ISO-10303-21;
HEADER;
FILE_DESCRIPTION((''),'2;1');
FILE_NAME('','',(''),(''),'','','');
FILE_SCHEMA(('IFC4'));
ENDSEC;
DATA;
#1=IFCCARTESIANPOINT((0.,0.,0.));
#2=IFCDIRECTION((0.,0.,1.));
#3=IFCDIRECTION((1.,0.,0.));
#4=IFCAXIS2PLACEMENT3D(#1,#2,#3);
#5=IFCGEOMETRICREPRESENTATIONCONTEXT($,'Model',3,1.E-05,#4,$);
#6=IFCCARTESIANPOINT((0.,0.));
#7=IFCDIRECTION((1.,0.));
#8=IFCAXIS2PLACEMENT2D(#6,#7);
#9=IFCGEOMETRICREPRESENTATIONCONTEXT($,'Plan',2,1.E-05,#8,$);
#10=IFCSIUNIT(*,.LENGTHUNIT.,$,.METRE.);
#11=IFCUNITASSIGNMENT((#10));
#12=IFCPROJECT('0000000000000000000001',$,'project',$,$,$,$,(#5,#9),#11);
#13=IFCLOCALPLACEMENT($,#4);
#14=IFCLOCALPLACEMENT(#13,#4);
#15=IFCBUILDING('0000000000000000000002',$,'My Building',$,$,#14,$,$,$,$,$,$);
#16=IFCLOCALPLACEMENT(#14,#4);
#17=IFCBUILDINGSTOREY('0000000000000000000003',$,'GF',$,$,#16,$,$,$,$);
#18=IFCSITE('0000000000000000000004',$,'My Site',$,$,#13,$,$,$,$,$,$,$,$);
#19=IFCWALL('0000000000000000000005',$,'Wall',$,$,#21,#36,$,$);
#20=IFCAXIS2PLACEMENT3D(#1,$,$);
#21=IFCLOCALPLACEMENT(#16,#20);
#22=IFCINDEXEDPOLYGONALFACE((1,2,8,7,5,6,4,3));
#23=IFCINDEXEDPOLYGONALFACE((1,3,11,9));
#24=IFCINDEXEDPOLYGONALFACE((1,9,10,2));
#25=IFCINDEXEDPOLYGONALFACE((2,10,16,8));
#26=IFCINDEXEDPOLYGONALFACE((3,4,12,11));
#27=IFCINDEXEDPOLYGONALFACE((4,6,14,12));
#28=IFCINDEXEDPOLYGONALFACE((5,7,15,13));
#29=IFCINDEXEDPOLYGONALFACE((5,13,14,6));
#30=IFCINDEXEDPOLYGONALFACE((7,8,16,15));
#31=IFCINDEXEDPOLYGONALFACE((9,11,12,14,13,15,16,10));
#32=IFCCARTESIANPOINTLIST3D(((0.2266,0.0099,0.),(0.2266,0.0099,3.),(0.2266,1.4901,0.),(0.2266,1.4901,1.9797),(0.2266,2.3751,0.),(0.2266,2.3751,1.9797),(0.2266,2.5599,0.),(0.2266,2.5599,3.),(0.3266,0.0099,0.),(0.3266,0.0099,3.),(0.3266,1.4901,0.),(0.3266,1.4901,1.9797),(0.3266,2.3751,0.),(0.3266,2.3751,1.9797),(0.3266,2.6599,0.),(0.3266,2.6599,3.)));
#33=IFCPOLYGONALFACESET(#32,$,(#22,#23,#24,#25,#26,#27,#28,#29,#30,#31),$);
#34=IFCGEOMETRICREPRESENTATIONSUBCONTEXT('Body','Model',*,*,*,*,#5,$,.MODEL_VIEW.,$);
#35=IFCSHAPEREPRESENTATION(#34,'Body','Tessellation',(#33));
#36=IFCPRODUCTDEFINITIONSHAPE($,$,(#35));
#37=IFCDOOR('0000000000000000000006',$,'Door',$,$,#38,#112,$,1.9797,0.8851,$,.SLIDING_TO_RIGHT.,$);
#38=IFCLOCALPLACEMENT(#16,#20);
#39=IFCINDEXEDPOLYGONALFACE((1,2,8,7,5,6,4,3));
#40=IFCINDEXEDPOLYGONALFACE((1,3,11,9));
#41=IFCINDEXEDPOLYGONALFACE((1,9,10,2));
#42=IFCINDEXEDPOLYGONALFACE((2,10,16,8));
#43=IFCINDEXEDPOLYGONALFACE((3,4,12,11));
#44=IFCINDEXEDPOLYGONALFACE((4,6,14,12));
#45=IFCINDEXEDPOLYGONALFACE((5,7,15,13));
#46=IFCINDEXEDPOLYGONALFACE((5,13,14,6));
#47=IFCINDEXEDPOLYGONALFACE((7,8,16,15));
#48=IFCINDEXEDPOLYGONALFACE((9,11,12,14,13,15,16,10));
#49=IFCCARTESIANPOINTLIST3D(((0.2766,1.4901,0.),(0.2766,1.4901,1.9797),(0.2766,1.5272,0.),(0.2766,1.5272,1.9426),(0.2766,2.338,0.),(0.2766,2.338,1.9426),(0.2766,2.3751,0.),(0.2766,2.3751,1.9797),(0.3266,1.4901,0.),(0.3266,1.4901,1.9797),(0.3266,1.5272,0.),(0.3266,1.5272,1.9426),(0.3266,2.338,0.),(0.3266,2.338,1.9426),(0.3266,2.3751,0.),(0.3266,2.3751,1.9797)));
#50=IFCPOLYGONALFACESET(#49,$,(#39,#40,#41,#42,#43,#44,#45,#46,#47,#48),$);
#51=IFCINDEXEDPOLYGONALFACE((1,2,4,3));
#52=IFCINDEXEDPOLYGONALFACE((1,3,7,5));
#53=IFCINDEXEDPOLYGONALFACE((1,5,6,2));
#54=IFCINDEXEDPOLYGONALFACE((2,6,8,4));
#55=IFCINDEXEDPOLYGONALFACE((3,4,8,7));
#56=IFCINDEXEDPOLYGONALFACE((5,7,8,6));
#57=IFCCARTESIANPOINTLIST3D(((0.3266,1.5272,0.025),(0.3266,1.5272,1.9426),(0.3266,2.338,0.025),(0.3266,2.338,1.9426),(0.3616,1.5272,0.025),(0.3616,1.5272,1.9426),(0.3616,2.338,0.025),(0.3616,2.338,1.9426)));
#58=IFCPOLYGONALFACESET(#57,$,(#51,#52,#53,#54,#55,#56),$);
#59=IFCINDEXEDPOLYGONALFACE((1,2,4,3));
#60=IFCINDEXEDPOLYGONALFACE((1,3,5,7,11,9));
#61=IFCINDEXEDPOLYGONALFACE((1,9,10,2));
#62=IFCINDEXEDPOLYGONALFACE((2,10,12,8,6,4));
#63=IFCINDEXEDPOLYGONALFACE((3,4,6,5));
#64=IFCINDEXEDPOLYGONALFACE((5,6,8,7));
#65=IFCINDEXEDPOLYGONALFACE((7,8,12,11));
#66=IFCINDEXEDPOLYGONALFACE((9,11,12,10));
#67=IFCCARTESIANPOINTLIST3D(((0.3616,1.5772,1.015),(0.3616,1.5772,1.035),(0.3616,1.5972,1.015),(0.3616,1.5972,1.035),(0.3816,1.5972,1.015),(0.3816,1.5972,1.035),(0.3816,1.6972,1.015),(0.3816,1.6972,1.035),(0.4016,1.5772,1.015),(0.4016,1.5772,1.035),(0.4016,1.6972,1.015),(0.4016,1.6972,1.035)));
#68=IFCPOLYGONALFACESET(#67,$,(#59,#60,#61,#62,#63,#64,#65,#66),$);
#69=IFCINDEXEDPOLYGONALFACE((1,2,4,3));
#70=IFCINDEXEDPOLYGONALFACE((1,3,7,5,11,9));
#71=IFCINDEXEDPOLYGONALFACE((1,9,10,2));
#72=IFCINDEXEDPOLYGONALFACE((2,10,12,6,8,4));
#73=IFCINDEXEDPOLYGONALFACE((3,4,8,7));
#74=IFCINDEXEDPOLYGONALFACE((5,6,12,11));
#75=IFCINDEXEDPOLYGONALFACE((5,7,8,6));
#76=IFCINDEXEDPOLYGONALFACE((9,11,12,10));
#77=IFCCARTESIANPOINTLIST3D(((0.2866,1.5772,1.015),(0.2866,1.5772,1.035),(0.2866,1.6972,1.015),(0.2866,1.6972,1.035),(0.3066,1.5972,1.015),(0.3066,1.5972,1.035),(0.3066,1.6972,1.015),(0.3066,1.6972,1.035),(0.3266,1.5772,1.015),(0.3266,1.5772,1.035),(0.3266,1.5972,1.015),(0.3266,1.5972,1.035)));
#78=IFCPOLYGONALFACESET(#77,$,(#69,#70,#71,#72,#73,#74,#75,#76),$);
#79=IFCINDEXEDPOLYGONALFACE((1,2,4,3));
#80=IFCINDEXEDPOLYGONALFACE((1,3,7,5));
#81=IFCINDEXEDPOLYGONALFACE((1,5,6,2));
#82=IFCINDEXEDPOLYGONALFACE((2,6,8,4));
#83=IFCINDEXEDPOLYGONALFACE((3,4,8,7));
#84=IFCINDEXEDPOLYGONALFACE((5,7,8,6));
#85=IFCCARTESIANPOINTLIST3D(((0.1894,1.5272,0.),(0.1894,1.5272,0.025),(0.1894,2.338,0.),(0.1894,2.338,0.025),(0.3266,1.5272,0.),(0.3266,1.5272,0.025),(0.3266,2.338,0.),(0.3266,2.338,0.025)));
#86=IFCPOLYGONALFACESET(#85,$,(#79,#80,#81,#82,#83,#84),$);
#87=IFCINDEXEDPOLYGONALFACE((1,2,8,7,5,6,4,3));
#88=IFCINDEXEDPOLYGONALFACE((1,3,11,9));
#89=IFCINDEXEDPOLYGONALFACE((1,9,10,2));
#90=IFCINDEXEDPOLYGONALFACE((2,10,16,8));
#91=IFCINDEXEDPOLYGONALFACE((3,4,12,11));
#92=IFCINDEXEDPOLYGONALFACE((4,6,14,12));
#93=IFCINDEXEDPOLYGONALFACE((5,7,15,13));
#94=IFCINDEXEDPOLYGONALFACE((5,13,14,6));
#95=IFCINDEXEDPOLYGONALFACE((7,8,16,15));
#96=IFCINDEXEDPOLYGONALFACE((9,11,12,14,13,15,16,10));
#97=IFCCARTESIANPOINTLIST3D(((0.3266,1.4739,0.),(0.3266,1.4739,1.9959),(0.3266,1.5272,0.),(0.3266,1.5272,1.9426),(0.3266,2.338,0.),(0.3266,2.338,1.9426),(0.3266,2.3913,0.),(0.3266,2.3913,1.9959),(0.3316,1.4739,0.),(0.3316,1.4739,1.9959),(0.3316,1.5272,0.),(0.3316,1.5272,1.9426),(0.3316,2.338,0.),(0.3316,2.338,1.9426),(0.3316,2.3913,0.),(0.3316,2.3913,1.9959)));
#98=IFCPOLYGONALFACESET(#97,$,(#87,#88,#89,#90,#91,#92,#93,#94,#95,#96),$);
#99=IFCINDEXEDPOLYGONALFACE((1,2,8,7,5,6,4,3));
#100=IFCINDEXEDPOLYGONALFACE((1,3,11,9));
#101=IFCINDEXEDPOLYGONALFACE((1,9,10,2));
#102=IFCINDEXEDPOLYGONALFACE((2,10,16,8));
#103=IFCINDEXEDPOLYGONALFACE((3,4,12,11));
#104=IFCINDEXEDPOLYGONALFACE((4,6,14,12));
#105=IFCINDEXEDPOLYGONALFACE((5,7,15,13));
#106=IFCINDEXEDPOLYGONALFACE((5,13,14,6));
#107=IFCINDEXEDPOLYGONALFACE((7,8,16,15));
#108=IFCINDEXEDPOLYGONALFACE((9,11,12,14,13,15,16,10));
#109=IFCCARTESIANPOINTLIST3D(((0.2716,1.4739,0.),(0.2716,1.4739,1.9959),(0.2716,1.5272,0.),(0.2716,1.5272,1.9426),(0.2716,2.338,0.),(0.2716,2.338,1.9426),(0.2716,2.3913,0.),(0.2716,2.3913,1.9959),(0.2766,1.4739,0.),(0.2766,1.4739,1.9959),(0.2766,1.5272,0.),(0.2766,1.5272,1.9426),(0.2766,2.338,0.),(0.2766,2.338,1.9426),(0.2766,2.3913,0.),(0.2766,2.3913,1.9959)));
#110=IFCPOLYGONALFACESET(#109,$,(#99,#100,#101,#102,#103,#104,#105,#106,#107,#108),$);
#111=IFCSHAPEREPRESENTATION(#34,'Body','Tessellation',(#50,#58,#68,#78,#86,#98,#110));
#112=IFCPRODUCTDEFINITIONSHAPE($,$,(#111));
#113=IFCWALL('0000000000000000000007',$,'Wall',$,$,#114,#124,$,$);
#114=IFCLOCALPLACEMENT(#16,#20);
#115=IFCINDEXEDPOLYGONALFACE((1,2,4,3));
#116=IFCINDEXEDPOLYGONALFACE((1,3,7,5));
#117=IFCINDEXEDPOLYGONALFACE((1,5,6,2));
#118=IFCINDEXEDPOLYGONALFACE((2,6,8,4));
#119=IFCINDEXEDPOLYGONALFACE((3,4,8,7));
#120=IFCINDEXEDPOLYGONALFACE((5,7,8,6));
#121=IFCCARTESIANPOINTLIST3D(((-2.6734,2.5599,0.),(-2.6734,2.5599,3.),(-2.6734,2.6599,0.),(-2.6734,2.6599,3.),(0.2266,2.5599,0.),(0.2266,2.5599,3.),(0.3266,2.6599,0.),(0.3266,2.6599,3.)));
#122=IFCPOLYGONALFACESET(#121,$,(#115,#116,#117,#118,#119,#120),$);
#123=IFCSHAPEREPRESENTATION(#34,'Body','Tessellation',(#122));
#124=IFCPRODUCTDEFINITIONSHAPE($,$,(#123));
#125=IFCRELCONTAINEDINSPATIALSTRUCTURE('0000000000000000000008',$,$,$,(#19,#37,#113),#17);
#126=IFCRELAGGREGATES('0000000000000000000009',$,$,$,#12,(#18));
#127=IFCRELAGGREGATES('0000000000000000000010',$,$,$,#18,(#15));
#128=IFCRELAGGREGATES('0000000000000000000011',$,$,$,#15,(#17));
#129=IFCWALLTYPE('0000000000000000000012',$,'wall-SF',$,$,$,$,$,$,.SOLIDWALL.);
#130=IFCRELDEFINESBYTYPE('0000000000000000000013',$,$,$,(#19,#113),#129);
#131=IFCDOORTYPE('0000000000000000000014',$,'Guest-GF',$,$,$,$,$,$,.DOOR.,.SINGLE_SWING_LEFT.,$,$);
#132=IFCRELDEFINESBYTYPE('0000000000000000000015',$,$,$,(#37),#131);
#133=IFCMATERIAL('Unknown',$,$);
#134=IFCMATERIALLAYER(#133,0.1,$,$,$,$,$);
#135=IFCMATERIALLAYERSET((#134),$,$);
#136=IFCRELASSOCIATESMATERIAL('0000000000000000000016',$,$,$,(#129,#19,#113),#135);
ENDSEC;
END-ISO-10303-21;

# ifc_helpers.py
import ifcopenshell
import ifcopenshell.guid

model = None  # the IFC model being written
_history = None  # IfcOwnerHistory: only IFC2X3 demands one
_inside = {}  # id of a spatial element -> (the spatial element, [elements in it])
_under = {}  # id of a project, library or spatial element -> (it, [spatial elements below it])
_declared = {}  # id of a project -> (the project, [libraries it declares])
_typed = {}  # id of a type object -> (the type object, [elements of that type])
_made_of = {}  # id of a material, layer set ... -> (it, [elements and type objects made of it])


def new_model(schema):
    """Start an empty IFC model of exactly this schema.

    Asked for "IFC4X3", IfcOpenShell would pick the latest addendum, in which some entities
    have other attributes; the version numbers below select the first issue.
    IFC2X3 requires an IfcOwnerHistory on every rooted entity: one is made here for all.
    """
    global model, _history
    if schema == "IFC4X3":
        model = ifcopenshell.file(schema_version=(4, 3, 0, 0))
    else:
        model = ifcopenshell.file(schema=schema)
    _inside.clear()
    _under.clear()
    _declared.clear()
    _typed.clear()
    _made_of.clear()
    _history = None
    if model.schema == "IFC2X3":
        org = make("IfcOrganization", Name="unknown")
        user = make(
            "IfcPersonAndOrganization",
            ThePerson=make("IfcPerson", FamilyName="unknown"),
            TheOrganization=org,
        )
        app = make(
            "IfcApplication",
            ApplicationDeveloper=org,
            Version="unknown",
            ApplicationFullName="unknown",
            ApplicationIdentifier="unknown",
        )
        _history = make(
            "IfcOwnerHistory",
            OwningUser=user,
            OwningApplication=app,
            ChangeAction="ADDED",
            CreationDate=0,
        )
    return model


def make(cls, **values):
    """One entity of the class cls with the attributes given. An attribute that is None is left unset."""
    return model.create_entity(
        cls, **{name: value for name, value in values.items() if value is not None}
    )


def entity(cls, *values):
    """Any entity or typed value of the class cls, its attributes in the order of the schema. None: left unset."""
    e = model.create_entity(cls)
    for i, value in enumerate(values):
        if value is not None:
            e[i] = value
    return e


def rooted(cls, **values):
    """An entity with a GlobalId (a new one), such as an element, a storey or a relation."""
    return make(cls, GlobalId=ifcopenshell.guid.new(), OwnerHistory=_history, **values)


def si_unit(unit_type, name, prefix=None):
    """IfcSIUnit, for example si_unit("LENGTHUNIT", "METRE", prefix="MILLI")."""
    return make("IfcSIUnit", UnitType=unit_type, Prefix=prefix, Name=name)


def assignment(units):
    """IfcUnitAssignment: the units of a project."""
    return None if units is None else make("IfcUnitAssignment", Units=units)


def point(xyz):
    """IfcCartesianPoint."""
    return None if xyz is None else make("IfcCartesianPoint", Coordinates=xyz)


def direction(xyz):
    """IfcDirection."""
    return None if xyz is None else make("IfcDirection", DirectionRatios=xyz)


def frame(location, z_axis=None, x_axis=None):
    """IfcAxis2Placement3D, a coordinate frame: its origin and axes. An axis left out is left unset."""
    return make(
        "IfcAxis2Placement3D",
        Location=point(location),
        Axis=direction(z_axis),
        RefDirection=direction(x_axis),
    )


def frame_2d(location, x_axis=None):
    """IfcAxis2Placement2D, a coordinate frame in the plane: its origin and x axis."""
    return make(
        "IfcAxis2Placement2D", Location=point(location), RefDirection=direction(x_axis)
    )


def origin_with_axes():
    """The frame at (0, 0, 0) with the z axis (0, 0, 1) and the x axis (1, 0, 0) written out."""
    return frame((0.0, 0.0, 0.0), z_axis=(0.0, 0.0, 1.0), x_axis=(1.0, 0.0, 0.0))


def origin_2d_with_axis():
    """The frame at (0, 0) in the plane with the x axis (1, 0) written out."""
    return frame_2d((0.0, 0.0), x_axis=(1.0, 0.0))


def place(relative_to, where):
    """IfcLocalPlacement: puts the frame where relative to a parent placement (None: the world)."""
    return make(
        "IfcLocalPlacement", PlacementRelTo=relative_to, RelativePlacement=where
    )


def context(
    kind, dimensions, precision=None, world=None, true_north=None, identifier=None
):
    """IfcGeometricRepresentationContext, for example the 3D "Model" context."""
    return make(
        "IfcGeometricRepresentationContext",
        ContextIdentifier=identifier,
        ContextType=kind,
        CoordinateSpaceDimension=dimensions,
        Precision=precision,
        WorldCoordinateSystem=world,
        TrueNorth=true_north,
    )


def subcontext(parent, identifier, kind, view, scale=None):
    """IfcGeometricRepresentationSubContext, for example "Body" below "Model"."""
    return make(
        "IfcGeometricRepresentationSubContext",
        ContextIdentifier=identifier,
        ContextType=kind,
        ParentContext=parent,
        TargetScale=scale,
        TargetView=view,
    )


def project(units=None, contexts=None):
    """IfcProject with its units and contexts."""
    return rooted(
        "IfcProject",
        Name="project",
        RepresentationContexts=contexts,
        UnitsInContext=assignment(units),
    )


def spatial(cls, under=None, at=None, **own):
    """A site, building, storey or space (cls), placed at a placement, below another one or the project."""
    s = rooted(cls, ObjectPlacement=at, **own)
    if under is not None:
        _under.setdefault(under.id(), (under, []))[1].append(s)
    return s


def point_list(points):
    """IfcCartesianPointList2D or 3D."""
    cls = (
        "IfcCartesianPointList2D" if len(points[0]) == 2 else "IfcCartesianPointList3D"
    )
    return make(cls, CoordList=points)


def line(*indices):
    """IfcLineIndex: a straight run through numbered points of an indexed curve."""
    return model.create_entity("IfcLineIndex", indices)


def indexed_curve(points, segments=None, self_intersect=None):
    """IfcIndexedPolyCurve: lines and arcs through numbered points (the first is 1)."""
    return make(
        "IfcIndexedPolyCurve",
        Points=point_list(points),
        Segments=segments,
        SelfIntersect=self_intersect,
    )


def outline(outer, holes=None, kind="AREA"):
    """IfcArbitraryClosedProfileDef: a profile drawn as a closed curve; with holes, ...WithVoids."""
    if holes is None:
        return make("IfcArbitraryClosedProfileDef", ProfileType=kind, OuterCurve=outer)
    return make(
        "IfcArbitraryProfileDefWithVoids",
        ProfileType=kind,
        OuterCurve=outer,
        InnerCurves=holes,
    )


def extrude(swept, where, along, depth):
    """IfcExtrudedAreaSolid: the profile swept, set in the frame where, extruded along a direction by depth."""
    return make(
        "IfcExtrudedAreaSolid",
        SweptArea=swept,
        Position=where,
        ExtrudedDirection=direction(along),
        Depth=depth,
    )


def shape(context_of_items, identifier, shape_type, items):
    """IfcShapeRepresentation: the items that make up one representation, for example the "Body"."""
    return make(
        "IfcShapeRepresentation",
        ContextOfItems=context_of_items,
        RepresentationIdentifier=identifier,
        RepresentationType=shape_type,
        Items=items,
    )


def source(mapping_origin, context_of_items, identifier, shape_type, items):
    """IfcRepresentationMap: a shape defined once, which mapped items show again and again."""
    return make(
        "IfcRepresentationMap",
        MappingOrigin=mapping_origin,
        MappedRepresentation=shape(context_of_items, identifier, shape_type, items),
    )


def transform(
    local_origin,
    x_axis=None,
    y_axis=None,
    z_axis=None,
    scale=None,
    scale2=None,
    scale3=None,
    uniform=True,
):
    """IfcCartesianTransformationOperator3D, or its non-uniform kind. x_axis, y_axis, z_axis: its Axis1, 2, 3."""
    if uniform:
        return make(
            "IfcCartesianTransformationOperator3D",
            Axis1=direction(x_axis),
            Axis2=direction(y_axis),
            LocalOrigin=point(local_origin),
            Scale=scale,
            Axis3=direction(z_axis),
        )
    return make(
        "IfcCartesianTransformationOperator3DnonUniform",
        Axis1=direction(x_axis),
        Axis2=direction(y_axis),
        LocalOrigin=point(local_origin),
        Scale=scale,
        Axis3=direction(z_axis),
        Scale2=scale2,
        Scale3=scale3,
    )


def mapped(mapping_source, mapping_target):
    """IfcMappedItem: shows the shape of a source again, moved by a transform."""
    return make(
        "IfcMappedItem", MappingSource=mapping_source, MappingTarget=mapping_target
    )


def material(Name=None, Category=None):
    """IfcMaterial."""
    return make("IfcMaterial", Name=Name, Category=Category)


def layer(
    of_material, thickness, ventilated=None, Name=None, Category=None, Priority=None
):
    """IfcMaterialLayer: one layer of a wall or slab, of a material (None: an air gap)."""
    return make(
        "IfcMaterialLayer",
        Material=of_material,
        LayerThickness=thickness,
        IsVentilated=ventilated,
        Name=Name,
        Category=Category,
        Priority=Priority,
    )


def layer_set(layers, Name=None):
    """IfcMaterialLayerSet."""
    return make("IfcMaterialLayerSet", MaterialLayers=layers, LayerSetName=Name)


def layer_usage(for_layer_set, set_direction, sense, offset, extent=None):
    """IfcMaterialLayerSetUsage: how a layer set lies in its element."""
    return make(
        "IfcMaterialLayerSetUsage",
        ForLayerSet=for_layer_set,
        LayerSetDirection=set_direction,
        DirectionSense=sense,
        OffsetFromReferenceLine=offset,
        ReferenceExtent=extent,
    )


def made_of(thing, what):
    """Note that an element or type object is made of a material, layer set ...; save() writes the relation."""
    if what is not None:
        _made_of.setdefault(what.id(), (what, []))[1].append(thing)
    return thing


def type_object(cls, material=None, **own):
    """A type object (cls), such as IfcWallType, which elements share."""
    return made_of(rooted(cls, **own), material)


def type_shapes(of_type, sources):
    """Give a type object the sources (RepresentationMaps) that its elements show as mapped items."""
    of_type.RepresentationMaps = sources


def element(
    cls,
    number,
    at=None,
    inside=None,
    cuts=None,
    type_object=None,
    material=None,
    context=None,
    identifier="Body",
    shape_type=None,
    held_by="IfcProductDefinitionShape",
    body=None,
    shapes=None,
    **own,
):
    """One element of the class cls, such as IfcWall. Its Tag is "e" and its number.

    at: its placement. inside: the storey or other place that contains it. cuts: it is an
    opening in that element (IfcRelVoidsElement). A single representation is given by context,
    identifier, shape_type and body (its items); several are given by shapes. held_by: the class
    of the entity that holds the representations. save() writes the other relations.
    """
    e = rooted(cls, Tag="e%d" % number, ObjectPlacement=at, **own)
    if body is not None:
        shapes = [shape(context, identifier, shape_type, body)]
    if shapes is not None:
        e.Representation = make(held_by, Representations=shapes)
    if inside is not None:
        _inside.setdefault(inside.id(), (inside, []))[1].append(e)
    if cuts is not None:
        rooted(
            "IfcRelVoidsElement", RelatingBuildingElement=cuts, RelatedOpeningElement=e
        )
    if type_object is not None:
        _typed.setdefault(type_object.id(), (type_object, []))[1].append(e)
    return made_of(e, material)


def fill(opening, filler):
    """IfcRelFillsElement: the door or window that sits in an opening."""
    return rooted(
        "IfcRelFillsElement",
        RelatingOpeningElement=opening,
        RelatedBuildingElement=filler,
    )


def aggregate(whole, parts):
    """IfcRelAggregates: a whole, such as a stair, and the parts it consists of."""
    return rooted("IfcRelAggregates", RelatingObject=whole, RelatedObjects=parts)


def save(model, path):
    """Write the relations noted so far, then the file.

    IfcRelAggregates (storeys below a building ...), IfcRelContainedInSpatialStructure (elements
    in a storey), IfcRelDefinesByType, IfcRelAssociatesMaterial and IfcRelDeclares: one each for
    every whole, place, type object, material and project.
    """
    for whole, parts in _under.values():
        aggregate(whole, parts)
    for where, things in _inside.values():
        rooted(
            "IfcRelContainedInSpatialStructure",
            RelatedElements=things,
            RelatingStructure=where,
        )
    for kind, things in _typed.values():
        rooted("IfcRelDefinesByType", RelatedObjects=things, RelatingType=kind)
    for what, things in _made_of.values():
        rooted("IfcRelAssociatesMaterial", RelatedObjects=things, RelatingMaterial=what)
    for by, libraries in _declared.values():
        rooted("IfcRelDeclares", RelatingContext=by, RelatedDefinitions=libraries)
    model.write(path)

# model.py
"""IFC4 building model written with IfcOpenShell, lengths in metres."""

from ifc_helpers import new_model, entity, si_unit, frame, origin_with_axes, origin_2d_with_axis, place, context, subcontext, project, spatial, line, indexed_curve, outline, extrude, shape, source, transform, mapped, material, layer, layer_set, layer_usage, type_object, type_shapes, element, fill, save


model = new_model("IFC4")

# Units and contexts
model_context = context("Model", 3, precision=1e-05, world=origin_with_axes())
plan_context = context("Plan", 2, precision=1e-05, world=origin_2d_with_axis())
body_context_1 = subcontext(model_context, "Body", "Model", "MODEL_VIEW")
body_context_2 = subcontext(plan_context, "Body", "Plan", "PLAN_VIEW")
ifc_project = project(units=[si_unit("LENGTHUNIT", "METRE")], contexts=[model_context, plan_context])

# Site, building, storey
site_placement = place(None, origin_with_axes())
site = spatial("IfcSite", under=ifc_project, at=site_placement, Name="My Site")
building_placement = place(site_placement, origin_with_axes())
building = spatial("IfcBuilding", under=site, at=building_placement, Name="My Building")
storey_placement = place(building_placement, origin_with_axes())
storey = spatial("IfcBuildingStorey", under=building, at=storey_placement, Name="GF")

# Shared definitions
ifc_material = material(Name="Unknown")

# Shared definitions
ifc_layer_1 = layer(ifc_material, 0.1)
ifc_layer_set_1 = layer_set([ifc_layer_1])
wall_type = type_object("IfcWallType", Name="wall-SF", PredefinedType="SOLIDWALL", material=ifc_layer_set_1)

# Wall, opening, door
ifc_layer_usage_1 = layer_usage(ifc_layer_set_1, "AXIS2", "POSITIVE", 0.0)
wall_1_placement = place(storey_placement, frame((0.3266, 0.0099, 0.0), z_axis=(0.0, 0.0, 1.0), x_axis=(0.0, 1.0, 0.0)))
wall_1 = element("IfcWall", 1, at=wall_1_placement, inside=storey, type_object=wall_type, material=ifc_layer_usage_1, Name="Wall", context=body_context_1, shape_type="SweptSolid", body=[
    extrude(outline(indexed_curve([(0.0, 0.0), (0.0, 0.1), (2.55, 0.1), (2.65, 0.0)], segments=[line(1, 2, 3, 4, 1)])), origin_with_axes(), (0.0, 0.0, 1.0), 3.0),
])
shared_shape_1 = source(origin_with_axes(), body_context_1, "Body", "SweptSolid", [
    extrude(outline(indexed_curve([(0.0, 0.0), (0.8851, 0.0), (0.8851, 1.9797), (0.0, 1.9797)], segments=[line(1, 2, 3, 4, 1)])), frame((0.0, -0.6, 0.0), z_axis=(0.0, -1.0, 0.0), x_axis=(1.0, 0.0, 0.0)), (0.0, 0.0, -1.0), 1.2),
])
opening_1_placement = place(wall_1_placement, frame((1.4802, 0.0, 0.0), z_axis=(0.0, 0.0, 1.0), x_axis=(1.0, 0.0, 0.0)))
opening_1 = element("IfcOpeningElement", 2, at=opening_1_placement, cuts=wall_1, PredefinedType="OPENING", context=body_context_1, shape_type="MappedRepresentation", body=[
    mapped(shared_shape_1, transform((0.0, 0.0, 0.0), x_axis=(1.0, 0.0, 0.0), y_axis=(0.0, 1.0, 0.0), z_axis=(0.0, 0.0, 1.0), scale=1.0)),
])
door_type_1 = type_object("IfcDoorType", Name="Guest-GF", OperationType="SINGLE_SWING_LEFT", PredefinedType="DOOR")
shared_shape_2 = source(origin_with_axes(), body_context_1, "Body", "SweptSolid", [
    extrude(outline(indexed_curve([(0.0, 0.0), (0.0, 1.9797), (0.8851, 1.9797), (0.8851, 0.0), (0.848, 0.0), (0.848, 1.9426), (0.0371, 1.9426), (0.0371, 0.0)], segments=[line(1, 2, 3, 4, 5, 6, 7, 8, 1)])), frame((0.0, 0.0, 0.0), z_axis=(0.0, -1.0, 0.0), x_axis=(1.0, 0.0, 0.0)), (0.0, 0.0, -1.0), 0.05),
    extrude(outline(indexed_curve([(0.0, 0.0), (0.8109, 0.0), (0.8109, 0.035), (0.0, 0.035)], segments=[line(1, 2, 3, 4, 1)])), frame((0.0371, -0.035, 0.025), z_axis=(0.0, 0.0, 1.0), x_axis=(1.0, 0.0, 0.0)), (0.0, 0.0, 1.0), 1.9176),
    extrude(outline(indexed_curve([(0.0, 0.0), (0.0, -0.04), (0.12, -0.04), (0.12, -0.02), (0.02, -0.02), (0.02, 0.0)], segments=[line(1, 2, 3, 4, 5, 6, 1)])), frame((0.0871, -0.035, 1.015), z_axis=(0.0, 0.0, 1.0), x_axis=(1.0, 0.0, 0.0)), (0.0, 0.0, 1.0), 0.02),
    extrude(outline(indexed_curve([(0.0, 0.0), (0.0, 0.04), (0.12, 0.04), (0.12, 0.02), (0.02, 0.02), (0.02, 0.0)], segments=[line(1, 2, 3, 4, 5, 6, 1)])), frame((0.0871, 0.0, 1.015), z_axis=(0.0, 0.0, 1.0), x_axis=(1.0, 0.0, 0.0)), (0.0, 0.0, 1.0), 0.02),
    extrude(outline(indexed_curve([(0.0, 0.0), (0.8109, 0.0), (0.8109, 0.1372), (0.0, 0.1372)], segments=[line(1, 2, 3, 4, 1)])), frame((0.0371, 0.0, 0.0), z_axis=(0.0, 0.0, 1.0), x_axis=(1.0, 0.0, 0.0)), (0.0, 0.0, 1.0), 0.025),
    extrude(outline(indexed_curve([(0.0, 0.0), (0.0, 1.9959), (0.9174, 1.9959), (0.9174, 0.0), (0.8641, 0.0), (0.8641, 1.9426), (0.0532, 1.9426), (0.0532, 0.0)], segments=[line(1, 2, 3, 4, 5, 6, 7, 8, 1)])), frame((-0.0162, -0.005, 0.0), z_axis=(0.0, -1.0, 0.0), x_axis=(1.0, 0.0, 0.0)), (0.0, 0.0, -1.0), 0.005),
    extrude(outline(indexed_curve([(0.0, 0.0), (0.0, 1.9959), (0.9174, 1.9959), (0.9174, 0.0), (0.8641, 0.0), (0.8641, 1.9426), (0.0532, 1.9426), (0.0532, 0.0)], segments=[line(1, 2, 3, 4, 5, 6, 7, 8, 1)])), frame((-0.0162, 0.05, 0.0), z_axis=(0.0, -1.0, 0.0), x_axis=(1.0, 0.0, 0.0)), (0.0, 0.0, -1.0), 0.005),
])
shared_shape_3 = source(origin_with_axes(), body_context_2, "Body", "Curve2D", [
    entity("IfcIndexedPolyCurve", entity("IfcCartesianPointList2D", [[0.0, 0.0], [0.0371, 0.0], [0.0371, 0.05], [0.0, 0.05]]), [entity("IfcLineIndex", [1, 2, 3, 4, 1])]),
    entity("IfcIndexedPolyCurve", entity("IfcCartesianPointList2D", [[0.8851, 0.0], [0.848, 0.0], [0.848, 0.05], [0.8851, 0.05]]), [entity("IfcLineIndex", [1, 2, 3, 4, 1])]),
    entity("IfcIndexedPolyCurve", entity("IfcCartesianPointList2D", [[1.2534, -0.035], [0.4425, -0.035], [0.4425, 0.0], [1.2534, 0.0]]), [entity("IfcLineIndex", [1, 2, 3, 4, 1])]),
])
type_shapes(door_type_1, [shared_shape_2, shared_shape_3])
door_1_placement = place(opening_1_placement, frame((0.0, 0.0, 0.0), z_axis=(0.0, 0.0, 1.0), x_axis=(1.0, 0.0, 0.0)))
door_1 = element("IfcDoor", 3, at=door_1_placement, inside=storey, type_object=door_type_1, Name="Door", OperationType="SLIDING_TO_RIGHT", OverallHeight=1.9797, OverallWidth=0.8851, shapes=[
    shape(body_context_1, "Body", "MappedRepresentation", [mapped(shared_shape_2, transform((0.0, 0.0, 0.0), x_axis=(1.0, 0.0, 0.0), y_axis=(0.0, 1.0, 0.0), z_axis=(0.0, 0.0, 1.0), scale=1.0))]),
    shape(body_context_2, "Body", "MappedRepresentation", [mapped(shared_shape_3, transform((0.0, 0.0, 0.0), x_axis=(1.0, 0.0, 0.0), y_axis=(0.0, 1.0, 0.0), z_axis=(0.0, 0.0, 1.0), scale=1.0))]),
])
fill(opening_1, door_1)

# Wall
ifc_layer_usage_2 = layer_usage(ifc_layer_set_1, "AXIS2", "POSITIVE", 0.0)
wall_2_placement = place(storey_placement, frame((0.3266, 2.6599, 0.0), z_axis=(0.0, 0.0, 1.0), x_axis=(-1.0, 0.0, 0.0)))
element("IfcWall", 4, at=wall_2_placement, inside=storey, type_object=wall_type, material=ifc_layer_usage_2, Name="Wall", context=body_context_1, shape_type="SweptSolid", body=[
    extrude(outline(indexed_curve([(0.0, 0.0), (0.1, 0.1), (3.0, 0.1), (3.0, 0.0)], segments=[line(1, 2, 3, 4, 1)])), origin_with_axes(), (0.0, 0.0, 1.0), 3.0),
])

save(model, "model.ifc")
